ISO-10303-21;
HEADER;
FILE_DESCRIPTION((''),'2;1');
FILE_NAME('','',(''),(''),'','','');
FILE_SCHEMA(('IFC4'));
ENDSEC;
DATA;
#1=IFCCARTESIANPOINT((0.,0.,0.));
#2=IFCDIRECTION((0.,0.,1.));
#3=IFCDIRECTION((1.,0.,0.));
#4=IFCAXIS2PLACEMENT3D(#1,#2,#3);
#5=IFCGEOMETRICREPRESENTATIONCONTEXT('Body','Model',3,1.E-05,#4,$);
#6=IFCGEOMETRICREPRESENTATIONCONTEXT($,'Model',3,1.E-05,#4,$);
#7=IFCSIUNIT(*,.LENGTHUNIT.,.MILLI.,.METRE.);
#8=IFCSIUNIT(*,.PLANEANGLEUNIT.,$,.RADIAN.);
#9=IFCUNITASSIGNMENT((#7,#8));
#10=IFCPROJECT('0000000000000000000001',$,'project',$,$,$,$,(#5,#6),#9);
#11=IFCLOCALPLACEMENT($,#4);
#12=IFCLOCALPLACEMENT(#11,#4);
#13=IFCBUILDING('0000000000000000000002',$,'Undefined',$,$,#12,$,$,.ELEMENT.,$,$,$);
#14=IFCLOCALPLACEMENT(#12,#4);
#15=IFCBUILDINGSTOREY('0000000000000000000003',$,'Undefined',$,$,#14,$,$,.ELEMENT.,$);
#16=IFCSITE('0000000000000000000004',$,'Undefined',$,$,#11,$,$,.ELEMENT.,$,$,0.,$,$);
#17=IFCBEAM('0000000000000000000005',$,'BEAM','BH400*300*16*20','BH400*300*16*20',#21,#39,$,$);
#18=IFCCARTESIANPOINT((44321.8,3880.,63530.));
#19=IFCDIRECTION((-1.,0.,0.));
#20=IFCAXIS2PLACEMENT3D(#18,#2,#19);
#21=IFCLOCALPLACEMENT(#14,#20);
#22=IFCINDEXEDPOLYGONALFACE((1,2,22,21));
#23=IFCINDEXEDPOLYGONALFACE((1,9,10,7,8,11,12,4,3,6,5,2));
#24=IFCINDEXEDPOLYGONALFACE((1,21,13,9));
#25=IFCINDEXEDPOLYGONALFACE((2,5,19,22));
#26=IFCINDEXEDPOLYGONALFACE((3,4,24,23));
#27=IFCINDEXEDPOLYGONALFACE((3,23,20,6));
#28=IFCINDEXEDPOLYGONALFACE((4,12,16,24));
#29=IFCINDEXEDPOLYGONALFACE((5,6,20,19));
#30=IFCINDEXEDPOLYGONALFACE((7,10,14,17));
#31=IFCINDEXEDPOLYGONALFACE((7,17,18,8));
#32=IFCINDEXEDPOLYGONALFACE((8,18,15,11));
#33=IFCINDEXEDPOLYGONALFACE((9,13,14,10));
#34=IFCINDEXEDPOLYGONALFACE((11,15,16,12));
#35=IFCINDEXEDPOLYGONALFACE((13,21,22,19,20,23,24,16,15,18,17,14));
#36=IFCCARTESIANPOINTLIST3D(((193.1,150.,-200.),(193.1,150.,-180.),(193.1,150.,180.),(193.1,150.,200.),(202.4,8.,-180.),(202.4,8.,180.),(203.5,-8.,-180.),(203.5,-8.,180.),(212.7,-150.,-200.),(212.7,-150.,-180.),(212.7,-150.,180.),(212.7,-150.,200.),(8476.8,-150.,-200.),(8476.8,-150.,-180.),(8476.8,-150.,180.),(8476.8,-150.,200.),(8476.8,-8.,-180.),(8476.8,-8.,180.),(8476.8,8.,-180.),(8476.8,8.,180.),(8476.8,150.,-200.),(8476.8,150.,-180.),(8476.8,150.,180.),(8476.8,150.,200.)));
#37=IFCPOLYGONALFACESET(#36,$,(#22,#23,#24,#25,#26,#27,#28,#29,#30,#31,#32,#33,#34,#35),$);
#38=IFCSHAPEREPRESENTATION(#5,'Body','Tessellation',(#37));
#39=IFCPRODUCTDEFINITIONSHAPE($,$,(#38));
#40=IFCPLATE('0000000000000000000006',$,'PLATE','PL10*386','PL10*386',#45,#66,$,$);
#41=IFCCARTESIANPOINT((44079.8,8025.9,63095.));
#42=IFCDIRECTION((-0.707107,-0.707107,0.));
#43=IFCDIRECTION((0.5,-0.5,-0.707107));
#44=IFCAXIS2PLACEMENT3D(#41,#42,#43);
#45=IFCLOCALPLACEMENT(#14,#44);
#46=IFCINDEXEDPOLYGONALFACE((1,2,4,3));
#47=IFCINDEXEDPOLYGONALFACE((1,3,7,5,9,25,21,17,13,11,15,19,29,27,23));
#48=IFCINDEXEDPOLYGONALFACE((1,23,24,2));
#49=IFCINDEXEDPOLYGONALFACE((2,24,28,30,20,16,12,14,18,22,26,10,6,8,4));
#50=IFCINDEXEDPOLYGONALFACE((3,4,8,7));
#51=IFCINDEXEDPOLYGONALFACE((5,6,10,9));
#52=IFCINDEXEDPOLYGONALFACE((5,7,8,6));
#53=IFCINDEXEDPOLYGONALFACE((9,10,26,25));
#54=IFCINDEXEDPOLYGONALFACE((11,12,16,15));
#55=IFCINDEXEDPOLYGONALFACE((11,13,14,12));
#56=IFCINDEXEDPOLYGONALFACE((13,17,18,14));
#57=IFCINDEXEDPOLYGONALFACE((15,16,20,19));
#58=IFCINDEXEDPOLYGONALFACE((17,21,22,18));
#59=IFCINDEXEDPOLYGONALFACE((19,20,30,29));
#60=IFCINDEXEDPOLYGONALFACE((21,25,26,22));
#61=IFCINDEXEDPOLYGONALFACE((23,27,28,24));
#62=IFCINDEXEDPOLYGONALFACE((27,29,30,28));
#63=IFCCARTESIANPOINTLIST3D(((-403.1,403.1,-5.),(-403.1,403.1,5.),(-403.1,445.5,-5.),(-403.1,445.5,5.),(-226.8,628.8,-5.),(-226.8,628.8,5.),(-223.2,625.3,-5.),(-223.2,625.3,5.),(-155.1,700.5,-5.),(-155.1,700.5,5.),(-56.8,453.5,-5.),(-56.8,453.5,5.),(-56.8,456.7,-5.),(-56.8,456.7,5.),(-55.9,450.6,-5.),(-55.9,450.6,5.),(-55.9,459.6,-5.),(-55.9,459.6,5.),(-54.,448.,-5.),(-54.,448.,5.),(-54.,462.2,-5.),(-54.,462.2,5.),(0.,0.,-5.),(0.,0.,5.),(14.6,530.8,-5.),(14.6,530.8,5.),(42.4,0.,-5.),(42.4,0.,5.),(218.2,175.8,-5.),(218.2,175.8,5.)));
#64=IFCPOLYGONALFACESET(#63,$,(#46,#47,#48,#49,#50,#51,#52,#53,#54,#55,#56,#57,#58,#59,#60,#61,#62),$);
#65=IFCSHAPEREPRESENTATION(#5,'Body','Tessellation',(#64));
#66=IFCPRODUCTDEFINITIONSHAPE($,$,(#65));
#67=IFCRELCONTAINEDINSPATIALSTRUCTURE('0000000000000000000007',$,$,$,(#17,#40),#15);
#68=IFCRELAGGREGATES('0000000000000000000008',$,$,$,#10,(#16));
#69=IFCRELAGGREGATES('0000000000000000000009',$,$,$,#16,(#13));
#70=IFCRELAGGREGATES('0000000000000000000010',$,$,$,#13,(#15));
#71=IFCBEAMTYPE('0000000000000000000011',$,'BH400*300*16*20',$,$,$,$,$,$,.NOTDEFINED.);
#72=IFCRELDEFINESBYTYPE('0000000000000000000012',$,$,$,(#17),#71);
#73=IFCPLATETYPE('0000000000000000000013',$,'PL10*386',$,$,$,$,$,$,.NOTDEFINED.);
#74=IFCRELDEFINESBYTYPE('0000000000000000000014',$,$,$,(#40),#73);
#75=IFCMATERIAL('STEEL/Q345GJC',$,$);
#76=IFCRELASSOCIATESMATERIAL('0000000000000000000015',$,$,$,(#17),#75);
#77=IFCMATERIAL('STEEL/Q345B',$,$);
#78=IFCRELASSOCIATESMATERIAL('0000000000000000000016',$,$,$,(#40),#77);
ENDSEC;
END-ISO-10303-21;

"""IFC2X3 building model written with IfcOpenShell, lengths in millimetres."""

from ifc_helpers import new_model, si_unit, frame, origin_with_axes, origin_2d_with_axis, place, context, project, spatial, polyline, i_section, outline, extrude, clip, halfspace, material, type_object, element, save


model = new_model("IFC2X3")

# Units and contexts
model_context_1 = context("Model", 3, precision=1e-05, world=origin_with_axes(), identifier="Body")
model_context_2 = context("Model", 3, precision=1e-05, world=origin_with_axes())
ifc_project = project(units=[si_unit("LENGTHUNIT", "METRE", prefix="MILLI"), si_unit("PLANEANGLEUNIT", "RADIAN")], contexts=[model_context_1, model_context_2])

# Site, building, storey
site_placement = place(None, origin_with_axes())
site = spatial("IfcSite", under=ifc_project, at=site_placement, Name="Undefined", CompositionType="ELEMENT", RefElevation=0.0)
building_placement = place(site_placement, origin_with_axes())
building = spatial("IfcBuilding", under=site, at=building_placement, Name="Undefined", CompositionType="ELEMENT")
storey_placement = place(building_placement, origin_with_axes())
storey = spatial("IfcBuildingStorey", under=building, at=storey_placement, Name="Undefined", CompositionType="ELEMENT")

# Beam
ifc_material_1 = material(Name="STEEL/Q345B")
ifc_material_2 = material(Name="STEEL/Q345GJC")
beam_type_1 = type_object("IfcBeamType", Name="BH400*300*16*20", PredefinedType="NOTDEFINED")
beam_1_placement = place(storey_placement, frame((44321.8, 3880.0, 63530.0), z_axis=(0.0, 0.0, 1.0), x_axis=(-1.0, 0.0, 0.0)))
element("IfcBeam", 1, at=beam_1_placement, inside=storey, type_object=beam_type_1, material=ifc_material_2, Name="BEAM", Description="BH400*300*16*20", ObjectType="BH400*300*16*20", context=model_context_1, shape_type="Clipping", body=[
    clip(clip(extrude(i_section(OverallWidth=300.0, OverallDepth=400.0, WebThickness=16.0, FlangeThickness=20.0, at=origin_2d_with_axis()), frame((8476.8, 0.0, 0.0), z_axis=(-1.0, 0.0, 0.0), x_axis=(0.0, -1.0, 0.0)), (0.0, 0.0, 1.0), 8283.8), halfspace(frame((8476.8, 70.8, 200.0), z_axis=(-1.0, 0.0, 0.0), x_axis=(0.0, 0.0, 1.0)), True)), halfspace(frame((202.1, 13.2, 300.0), z_axis=(-0.997873, -0.065183, 0.0), x_axis=(0.065183, -0.997873, 0.0)), False)),
])

# Plate
plate_type_1 = type_object("IfcPlateType", Name="PL10*386", PredefinedType="NOTDEFINED")
plate_1_placement = place(storey_placement, frame((44079.8, 8025.9, 63095.0), z_axis=(-0.707107, -0.707107, 0.0), x_axis=(0.5, -0.5, -0.707107)))
element("IfcPlate", 2, at=plate_1_placement, inside=storey, type_object=plate_type_1, material=ifc_material_1, Name="PLATE", Description="PL10*386", ObjectType="PL10*386", context=model_context_1, shape_type="SweptSolid", body=[
    extrude(outline(polyline([(0.0, 0.0), (42.4, 0.0), (218.2, 175.8), (-54.0, 448.0), (-55.9, 450.6), (-56.8, 453.5), (-56.8, 456.7), (-55.9, 459.6), (-54.0, 462.2), (14.6, 530.8), (-155.1, 700.5), (-226.8, 628.8), (-223.2, 625.3), (-403.1, 445.5), (-403.1, 403.1), (0.0, 0.0)])), frame((0.0, 0.0, -5.0), z_axis=(0.0, 0.0, 1.0), x_axis=(1.0, 0.0, 0.0)), (0.0, 0.0, 1.0), 10.0),
])

save(model, "model.ifc")
